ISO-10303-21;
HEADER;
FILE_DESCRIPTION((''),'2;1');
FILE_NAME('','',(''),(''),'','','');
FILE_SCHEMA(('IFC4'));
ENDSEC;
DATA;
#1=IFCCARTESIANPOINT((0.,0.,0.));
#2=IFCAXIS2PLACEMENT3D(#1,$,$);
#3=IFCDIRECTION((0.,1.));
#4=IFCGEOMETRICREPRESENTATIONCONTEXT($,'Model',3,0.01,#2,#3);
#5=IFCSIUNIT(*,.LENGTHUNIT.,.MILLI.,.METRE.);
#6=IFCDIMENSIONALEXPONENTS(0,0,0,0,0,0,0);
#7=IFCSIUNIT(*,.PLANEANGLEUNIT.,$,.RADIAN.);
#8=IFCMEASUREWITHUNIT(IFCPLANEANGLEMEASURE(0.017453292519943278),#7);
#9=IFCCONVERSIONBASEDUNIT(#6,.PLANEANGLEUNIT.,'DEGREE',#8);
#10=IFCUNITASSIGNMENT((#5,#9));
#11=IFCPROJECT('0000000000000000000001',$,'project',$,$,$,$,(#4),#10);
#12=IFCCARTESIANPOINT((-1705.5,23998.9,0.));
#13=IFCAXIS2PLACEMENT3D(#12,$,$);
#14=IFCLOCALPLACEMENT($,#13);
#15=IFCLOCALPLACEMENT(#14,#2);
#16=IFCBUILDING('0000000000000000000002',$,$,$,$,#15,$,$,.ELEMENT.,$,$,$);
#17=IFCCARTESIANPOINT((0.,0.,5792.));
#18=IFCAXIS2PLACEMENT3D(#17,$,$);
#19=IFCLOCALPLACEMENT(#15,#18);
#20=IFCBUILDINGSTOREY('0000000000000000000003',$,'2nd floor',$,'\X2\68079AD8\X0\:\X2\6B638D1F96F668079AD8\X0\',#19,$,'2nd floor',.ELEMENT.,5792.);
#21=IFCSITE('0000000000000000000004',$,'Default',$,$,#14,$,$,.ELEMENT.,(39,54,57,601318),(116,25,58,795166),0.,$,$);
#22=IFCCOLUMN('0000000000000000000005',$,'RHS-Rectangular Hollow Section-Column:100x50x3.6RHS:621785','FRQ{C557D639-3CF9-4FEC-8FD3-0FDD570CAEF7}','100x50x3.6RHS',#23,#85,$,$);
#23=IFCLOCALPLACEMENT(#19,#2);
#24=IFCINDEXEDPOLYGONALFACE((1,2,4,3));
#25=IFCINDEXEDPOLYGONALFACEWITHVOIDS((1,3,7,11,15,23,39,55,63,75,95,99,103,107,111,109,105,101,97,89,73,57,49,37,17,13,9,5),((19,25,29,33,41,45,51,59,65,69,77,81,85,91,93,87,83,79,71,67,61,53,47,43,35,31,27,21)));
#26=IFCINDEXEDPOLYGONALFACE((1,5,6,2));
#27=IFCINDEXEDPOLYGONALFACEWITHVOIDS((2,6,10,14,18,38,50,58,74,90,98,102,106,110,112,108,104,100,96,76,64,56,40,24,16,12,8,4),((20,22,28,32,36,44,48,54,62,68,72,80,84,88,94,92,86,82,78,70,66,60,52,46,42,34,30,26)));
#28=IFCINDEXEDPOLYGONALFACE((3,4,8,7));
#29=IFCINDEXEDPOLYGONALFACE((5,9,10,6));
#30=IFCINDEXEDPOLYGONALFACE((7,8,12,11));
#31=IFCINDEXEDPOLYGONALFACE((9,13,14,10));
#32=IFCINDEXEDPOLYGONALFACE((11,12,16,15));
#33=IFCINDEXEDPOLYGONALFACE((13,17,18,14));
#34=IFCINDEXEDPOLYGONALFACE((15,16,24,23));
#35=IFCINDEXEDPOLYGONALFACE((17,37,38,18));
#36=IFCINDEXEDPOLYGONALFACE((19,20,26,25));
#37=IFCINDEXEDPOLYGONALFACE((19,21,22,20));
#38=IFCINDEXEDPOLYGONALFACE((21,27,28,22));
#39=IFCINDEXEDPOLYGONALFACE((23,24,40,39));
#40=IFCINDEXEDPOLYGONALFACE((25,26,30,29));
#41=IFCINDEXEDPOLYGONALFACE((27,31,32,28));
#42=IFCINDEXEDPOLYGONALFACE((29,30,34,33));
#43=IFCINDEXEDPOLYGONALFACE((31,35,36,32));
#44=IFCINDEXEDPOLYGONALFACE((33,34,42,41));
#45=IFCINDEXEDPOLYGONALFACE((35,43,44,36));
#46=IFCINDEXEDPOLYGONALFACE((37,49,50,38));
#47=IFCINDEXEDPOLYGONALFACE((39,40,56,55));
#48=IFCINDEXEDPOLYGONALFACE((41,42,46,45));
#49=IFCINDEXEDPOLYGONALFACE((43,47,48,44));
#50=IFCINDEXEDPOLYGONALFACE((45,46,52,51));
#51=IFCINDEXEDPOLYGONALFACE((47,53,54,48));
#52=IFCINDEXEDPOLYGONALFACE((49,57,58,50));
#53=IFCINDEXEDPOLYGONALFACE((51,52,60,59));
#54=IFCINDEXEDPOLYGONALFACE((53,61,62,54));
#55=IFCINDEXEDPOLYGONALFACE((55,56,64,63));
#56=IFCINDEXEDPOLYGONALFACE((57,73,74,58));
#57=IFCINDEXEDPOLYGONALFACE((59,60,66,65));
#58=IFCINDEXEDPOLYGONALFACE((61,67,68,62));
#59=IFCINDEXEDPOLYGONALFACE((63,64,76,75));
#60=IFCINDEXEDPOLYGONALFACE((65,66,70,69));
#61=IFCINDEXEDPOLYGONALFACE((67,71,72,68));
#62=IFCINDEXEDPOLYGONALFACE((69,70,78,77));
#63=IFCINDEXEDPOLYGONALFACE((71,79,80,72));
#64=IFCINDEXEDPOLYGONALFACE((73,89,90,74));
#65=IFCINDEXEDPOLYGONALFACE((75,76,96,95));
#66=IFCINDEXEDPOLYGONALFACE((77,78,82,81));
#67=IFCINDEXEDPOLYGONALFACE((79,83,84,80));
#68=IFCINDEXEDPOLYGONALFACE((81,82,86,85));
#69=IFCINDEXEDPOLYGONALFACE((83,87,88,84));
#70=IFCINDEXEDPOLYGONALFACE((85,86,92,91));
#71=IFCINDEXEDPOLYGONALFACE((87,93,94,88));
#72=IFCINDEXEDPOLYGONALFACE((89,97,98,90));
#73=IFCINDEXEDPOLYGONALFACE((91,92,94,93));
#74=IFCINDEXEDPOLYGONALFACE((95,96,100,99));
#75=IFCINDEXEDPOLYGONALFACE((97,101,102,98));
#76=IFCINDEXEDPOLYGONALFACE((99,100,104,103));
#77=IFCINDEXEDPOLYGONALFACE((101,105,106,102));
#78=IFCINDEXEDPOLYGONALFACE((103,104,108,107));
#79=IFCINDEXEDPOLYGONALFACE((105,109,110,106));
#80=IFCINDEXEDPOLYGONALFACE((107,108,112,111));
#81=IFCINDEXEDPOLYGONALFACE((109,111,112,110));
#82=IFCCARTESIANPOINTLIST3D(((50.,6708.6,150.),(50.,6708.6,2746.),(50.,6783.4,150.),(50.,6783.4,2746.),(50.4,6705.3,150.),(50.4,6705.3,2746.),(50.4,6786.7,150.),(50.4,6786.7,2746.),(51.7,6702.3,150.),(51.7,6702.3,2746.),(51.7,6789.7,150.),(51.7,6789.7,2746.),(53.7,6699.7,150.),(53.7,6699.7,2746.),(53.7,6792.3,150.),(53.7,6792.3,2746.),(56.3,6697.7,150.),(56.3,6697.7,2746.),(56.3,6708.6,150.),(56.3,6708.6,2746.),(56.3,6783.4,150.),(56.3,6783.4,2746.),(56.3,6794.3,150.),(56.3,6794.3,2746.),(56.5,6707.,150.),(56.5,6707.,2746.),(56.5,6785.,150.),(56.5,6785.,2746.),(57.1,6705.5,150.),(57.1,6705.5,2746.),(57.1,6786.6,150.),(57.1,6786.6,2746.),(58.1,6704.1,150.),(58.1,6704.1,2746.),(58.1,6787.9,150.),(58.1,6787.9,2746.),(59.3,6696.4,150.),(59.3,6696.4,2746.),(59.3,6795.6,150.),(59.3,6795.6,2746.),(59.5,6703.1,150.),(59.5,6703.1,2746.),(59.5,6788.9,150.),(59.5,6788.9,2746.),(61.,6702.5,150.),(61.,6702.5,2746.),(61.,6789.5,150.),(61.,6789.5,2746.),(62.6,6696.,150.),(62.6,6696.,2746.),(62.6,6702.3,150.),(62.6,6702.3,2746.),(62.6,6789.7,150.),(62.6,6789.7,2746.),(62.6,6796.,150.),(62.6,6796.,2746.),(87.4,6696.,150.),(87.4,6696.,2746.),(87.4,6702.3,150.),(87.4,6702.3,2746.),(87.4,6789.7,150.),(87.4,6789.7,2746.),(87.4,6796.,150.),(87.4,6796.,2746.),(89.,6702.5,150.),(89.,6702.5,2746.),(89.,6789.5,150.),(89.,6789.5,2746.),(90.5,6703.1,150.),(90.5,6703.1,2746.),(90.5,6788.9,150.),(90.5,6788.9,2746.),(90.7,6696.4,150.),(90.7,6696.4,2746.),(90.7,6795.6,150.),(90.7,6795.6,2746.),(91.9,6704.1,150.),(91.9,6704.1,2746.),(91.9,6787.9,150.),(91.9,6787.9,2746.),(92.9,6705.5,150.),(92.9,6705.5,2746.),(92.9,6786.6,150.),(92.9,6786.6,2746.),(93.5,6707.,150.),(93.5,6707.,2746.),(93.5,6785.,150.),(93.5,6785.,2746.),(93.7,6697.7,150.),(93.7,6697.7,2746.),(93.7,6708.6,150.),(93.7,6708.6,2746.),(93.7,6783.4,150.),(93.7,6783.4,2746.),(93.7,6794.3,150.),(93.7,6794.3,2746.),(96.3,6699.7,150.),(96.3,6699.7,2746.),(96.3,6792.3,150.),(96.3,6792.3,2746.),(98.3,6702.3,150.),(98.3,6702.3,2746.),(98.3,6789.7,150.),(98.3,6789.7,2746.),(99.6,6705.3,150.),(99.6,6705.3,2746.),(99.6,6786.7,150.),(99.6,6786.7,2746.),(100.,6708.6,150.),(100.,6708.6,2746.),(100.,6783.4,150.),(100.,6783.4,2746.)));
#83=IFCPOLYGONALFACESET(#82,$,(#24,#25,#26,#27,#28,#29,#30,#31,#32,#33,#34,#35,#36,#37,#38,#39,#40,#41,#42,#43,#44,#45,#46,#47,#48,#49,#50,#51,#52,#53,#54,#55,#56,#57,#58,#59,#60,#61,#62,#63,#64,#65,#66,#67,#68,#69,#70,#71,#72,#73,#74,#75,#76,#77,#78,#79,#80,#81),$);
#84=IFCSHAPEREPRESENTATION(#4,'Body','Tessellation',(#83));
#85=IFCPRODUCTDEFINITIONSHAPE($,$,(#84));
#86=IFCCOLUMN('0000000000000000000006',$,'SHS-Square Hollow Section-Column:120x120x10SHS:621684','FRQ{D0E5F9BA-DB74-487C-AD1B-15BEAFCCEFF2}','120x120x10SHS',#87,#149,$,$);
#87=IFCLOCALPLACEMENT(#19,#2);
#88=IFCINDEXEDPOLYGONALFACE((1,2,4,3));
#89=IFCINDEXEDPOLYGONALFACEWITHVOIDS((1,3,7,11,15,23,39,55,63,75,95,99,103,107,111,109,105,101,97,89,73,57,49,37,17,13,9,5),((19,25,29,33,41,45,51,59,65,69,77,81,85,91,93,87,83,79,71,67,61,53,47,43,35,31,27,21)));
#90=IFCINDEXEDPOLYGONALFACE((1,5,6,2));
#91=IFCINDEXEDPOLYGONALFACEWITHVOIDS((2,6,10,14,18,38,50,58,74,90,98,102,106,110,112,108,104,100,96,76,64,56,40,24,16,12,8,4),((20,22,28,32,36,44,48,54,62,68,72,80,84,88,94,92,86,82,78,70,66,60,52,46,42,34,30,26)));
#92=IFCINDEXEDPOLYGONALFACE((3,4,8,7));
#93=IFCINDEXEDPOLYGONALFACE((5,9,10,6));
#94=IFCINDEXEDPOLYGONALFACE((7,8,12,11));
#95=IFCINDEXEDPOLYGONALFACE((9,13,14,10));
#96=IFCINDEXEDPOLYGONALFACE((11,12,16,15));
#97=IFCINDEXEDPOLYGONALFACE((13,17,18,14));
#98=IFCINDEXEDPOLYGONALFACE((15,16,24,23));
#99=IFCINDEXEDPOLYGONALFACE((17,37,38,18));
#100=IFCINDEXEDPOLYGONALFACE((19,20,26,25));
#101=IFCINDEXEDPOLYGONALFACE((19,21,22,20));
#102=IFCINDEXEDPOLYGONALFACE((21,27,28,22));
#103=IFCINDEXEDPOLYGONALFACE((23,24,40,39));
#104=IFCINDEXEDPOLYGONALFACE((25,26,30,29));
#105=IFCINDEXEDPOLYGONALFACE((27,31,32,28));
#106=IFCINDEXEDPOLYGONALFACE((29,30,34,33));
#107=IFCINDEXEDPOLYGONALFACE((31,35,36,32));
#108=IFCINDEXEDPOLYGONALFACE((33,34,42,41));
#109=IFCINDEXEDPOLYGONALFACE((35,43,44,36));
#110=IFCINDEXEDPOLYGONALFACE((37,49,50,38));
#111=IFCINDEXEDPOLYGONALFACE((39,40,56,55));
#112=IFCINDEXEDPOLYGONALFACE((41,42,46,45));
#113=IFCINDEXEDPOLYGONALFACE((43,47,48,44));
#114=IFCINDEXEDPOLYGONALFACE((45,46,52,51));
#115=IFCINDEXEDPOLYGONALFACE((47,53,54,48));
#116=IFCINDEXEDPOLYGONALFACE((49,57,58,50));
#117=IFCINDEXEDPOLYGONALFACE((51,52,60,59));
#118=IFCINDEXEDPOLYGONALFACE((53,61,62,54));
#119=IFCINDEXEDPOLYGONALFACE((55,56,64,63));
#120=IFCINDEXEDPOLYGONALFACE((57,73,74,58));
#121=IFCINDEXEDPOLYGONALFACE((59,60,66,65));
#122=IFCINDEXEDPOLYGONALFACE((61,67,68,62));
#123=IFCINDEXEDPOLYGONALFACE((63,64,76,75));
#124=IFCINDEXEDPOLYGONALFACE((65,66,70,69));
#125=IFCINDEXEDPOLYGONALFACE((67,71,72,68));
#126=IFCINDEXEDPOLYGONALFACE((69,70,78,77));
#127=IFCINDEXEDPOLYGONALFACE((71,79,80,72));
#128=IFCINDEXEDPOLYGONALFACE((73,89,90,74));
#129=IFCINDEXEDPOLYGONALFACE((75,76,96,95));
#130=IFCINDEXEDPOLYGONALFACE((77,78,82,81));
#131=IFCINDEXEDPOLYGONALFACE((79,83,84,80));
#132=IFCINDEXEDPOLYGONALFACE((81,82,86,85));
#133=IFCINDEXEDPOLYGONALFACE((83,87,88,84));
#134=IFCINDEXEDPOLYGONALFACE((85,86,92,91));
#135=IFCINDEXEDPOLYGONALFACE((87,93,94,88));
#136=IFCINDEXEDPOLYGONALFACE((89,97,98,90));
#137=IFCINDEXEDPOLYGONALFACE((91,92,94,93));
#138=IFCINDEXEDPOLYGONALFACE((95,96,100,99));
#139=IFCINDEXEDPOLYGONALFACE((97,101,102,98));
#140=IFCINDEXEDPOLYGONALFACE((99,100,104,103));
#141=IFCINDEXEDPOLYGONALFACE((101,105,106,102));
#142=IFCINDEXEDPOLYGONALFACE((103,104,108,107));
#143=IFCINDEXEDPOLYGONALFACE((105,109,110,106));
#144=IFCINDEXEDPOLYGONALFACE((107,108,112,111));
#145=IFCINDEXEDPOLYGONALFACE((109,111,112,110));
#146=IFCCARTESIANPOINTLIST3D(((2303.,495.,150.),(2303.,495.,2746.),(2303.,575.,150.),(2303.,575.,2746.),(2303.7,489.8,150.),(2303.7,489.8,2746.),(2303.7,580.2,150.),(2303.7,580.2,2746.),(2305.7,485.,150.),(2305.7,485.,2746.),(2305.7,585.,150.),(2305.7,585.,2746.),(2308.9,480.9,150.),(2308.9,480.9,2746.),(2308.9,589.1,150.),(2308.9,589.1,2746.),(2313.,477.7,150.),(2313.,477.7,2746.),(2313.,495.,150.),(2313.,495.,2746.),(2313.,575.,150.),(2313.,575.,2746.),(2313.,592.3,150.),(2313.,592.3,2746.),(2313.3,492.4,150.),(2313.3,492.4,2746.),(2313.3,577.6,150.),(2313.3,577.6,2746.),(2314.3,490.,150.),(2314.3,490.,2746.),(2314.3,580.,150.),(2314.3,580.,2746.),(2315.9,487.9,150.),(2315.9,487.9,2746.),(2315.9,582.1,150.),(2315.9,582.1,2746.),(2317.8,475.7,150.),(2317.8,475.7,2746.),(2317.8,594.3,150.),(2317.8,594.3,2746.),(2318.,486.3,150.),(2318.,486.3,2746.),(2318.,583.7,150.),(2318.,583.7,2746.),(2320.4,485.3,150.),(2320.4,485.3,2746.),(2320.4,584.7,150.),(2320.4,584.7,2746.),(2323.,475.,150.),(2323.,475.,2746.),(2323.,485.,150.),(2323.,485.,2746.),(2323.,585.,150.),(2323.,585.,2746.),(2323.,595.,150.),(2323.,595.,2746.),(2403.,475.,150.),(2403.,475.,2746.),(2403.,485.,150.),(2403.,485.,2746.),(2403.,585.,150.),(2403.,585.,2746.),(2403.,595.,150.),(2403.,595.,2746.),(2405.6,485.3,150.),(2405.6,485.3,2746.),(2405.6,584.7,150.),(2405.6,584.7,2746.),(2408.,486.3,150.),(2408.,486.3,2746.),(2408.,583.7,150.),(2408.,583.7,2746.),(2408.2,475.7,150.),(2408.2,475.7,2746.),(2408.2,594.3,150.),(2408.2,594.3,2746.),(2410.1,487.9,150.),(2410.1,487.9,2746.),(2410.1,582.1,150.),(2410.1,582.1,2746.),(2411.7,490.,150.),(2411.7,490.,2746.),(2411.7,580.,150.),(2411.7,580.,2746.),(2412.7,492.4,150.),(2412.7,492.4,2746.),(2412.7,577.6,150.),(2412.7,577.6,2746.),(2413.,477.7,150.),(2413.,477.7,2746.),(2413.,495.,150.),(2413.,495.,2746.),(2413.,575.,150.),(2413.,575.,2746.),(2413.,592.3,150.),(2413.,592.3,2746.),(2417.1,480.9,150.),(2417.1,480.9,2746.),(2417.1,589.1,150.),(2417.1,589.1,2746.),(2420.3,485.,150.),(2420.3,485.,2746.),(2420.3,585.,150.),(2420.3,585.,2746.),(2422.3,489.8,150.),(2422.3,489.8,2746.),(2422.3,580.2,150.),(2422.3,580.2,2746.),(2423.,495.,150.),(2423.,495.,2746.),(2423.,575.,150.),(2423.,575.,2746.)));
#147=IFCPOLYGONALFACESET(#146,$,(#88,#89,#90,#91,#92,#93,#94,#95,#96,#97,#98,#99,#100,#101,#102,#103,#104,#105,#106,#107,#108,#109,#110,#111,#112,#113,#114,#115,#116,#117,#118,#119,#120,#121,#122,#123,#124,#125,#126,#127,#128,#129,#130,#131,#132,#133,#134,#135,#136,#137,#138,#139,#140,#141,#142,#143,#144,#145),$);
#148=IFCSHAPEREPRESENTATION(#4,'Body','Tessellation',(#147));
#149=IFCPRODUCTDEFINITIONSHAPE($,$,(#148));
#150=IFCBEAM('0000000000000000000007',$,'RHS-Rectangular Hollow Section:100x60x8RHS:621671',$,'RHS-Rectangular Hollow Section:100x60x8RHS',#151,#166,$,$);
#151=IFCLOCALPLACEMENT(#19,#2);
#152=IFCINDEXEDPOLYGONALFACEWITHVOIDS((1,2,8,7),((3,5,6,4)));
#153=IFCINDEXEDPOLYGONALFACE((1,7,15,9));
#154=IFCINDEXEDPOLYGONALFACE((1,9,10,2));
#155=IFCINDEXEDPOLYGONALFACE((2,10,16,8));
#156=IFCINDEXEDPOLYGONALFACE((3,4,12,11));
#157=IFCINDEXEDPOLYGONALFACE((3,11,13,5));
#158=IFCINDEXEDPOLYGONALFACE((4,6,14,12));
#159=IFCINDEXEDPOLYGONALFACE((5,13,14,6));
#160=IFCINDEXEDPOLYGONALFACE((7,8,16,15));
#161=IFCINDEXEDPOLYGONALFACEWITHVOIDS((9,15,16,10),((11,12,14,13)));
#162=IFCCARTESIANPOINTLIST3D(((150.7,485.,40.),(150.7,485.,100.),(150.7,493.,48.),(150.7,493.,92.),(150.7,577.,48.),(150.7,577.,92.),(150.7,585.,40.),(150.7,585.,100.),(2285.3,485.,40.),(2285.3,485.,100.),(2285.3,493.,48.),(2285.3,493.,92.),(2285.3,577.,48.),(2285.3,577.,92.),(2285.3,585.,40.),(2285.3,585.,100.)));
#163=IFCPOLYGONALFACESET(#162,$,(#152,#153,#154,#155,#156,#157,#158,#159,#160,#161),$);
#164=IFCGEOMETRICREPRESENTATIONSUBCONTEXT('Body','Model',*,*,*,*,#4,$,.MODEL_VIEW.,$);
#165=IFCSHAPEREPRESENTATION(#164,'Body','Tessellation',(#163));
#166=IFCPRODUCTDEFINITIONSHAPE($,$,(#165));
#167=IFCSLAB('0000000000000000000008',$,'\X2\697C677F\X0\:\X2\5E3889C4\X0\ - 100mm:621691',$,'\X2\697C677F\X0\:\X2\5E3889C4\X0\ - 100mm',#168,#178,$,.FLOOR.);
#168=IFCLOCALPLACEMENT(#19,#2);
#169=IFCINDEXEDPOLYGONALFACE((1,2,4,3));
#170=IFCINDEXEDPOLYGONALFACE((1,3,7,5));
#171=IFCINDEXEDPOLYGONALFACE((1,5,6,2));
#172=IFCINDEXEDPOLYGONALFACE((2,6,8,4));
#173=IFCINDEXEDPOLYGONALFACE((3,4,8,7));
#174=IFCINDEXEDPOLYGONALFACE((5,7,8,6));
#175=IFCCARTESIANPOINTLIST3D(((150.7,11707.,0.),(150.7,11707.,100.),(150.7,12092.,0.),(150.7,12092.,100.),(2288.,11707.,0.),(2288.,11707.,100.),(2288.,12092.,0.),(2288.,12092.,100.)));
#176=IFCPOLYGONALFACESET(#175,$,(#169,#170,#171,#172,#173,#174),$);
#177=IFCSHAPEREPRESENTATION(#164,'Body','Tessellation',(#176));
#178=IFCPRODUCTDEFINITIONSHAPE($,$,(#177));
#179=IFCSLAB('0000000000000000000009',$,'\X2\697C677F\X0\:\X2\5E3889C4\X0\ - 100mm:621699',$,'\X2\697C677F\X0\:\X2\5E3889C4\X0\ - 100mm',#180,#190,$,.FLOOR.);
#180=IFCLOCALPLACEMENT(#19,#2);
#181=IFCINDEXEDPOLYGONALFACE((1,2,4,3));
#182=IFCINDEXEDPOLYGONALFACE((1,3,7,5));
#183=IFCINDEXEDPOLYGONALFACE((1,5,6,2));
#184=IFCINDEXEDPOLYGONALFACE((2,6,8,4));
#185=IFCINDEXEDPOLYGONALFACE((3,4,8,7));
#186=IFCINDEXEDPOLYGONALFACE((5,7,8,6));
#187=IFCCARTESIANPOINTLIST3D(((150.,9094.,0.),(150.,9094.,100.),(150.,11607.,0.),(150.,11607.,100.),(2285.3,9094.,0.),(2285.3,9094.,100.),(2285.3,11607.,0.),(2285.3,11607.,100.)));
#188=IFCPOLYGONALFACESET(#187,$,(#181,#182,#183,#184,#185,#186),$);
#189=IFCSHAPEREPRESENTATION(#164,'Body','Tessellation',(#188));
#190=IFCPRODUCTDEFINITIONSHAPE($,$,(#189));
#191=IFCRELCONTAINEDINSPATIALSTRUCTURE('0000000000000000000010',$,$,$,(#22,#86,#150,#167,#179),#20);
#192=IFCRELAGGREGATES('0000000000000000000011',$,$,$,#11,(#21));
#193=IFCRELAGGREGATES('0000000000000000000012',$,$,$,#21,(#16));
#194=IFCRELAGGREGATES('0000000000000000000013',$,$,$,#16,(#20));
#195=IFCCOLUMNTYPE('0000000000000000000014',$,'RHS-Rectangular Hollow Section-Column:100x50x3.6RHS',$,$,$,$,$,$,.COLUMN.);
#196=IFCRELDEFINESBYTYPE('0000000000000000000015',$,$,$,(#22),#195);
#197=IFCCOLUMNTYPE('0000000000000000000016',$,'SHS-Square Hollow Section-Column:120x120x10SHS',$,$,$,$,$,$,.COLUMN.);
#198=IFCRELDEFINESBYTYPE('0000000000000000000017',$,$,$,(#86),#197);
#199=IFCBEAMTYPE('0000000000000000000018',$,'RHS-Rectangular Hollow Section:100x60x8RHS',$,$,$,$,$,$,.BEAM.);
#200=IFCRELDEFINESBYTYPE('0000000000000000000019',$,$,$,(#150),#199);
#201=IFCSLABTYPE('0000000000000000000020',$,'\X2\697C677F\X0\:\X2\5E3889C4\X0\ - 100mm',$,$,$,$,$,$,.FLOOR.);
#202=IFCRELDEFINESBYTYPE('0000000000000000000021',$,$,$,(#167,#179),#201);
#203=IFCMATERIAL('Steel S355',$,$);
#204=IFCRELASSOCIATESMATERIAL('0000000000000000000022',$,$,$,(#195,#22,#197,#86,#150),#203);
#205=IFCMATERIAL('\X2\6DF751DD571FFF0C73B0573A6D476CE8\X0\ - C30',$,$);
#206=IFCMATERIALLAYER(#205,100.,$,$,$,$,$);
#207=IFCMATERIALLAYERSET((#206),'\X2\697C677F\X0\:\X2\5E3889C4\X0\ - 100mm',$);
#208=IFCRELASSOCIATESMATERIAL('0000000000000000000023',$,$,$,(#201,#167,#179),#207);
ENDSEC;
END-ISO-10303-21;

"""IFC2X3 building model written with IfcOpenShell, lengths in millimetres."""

from ifc_helpers import new_model, entity, si_unit, converted_unit, direction, frame, frame_2d, origin, origin_2d, origin_2d_with_axis, place, context, subcontext, project, spatial, rectangle, hollow_rectangle, extrude, boolean, clip, halfspace, material, layer, layer_set, layer_usage, type_object, element, save


model = new_model("IFC2X3")

# Units and contexts
model_context = context("Model", 3, precision=0.01, world=origin(), true_north=direction((0.0, 1.0)))
body_context = subcontext(model_context, "Body", "Model", "MODEL_VIEW")
ifc_project = project(units=[si_unit("LENGTHUNIT", "METRE", prefix="MILLI"), converted_unit("PLANEANGLEUNIT", "DEGREE", entity("IfcPlaneAngleMeasure", 0.017453292519943278), si_unit("PLANEANGLEUNIT", "RADIAN"), dimensions=[0, 0, 0, 0, 0, 0, 0])], contexts=[model_context])

# Site, building, storey
site_placement = place(None, frame((-1705.5, 23998.9, 0.0)))
site = spatial("IfcSite", under=ifc_project, at=site_placement, Name="Default", CompositionType="ELEMENT", RefLatitude=(39, 54, 57, 601318), RefLongitude=(116, 25, 58, 795166), RefElevation=0.0)
building_placement = place(site_placement, origin())
building = spatial("IfcBuilding", under=site, at=building_placement, CompositionType="ELEMENT")
storey_placement = place(building_placement, frame((0.0, 0.0, 5792.0)))
storey = spatial("IfcBuildingStorey", under=building, at=storey_placement, Name="2nd floor", ObjectType="标高:正负零标高", LongName="2nd floor", CompositionType="ELEMENT", Elevation=5792.0)

# Shared definitions
ifc_material_1 = material(Name="Steel S355")

# Columns
column_type_1 = type_object("IfcColumnType", Name="RHS-Rectangular Hollow Section-Column:100x50x3.6RHS", PredefinedType="COLUMN", material=ifc_material_1)
column_1_placement = place(storey_placement, frame((75.0, 6746.0, 2746.0), z_axis=(0.0, 0.0, 1.0), x_axis=(-1.0, 0.0, 0.0)))
element("IfcColumn", 1, at=column_1_placement, inside=storey, type_object=column_type_1, material=ifc_material_1, Name="RHS-Rectangular Hollow Section-Column:100x50x3.6RHS:621785", Description="FRQ{C557D639-3CF9-4FEC-8FD3-0FDD570CAEF7}", ObjectType="100x50x3.6RHS", context=model_context, shape_type="Clipping", body=[
    clip(extrude(hollow_rectangle(XDim=50.0, YDim=100.0, WallThickness=6.3, InnerFilletRadius=6.3, OuterFilletRadius=12.6, at=origin_2d()), origin(), (0.0, 0.0, -1.0), 2651.9), halfspace(frame((75.0, 6746.0, -2596.0), z_axis=(0.0, 0.0, 1.0), x_axis=(-1.0, 0.0, 0.0)), True)),
])
column_type_2 = type_object("IfcColumnType", Name="SHS-Square Hollow Section-Column:120x120x10SHS", PredefinedType="COLUMN", material=ifc_material_1)
column_2_placement = place(storey_placement, frame((2363.0, 535.0, 2746.0), z_axis=(0.0, 0.0, 1.0), x_axis=(0.0, -1.0, 0.0)))
element("IfcColumn", 2, at=column_2_placement, inside=storey, type_object=column_type_2, material=ifc_material_1, Name="SHS-Square Hollow Section-Column:120x120x10SHS:621684", Description="FRQ{D0E5F9BA-DB74-487C-AD1B-15BEAFCCEFF2}", ObjectType="120x120x10SHS", context=model_context, shape_type="Clipping", body=[
    clip(extrude(hollow_rectangle(XDim=120.0, YDim=120.0, WallThickness=10.0, InnerFilletRadius=10.0, OuterFilletRadius=20.0, at=origin_2d()), origin(), (0.0, 0.0, -1.0), 2680.9), halfspace(frame((535.0, -2363.0, -2596.0), z_axis=(0.0, 0.0, 1.0), x_axis=(0.0, 1.0, 0.0)), True)),
])

# Beam
beam_type_1 = type_object("IfcBeamType", Name="RHS-Rectangular Hollow Section:100x60x8RHS", PredefinedType="BEAM")
beam_1_placement = place(storey_placement, frame((150.7, 585.0, 70.0)))
element("IfcBeam", 3, at=beam_1_placement, inside=storey, type_object=beam_type_1, material=ifc_material_1, Name="RHS-Rectangular Hollow Section:100x60x8RHS:621671", ObjectType="RHS-Rectangular Hollow Section:100x60x8RHS", context=body_context, shape_type="SweptSolid", body=[
    boolean("DIFFERENCE", extrude(rectangle(XDim=60.0, YDim=100.0, at=frame_2d((0.0, 0.0), x_axis=(1.0, 0.0))), frame((0.0, -50.0, 0.0), z_axis=(1.0, 0.0, 0.0), x_axis=(0.0, 0.0, -1.0)), (0.0, 0.0, 1.0), 2134.6), extrude(rectangle(XDim=44.0, YDim=84.0, at=frame_2d((0.0, 0.0), x_axis=(0.0, 1.0))), frame((2134.6, -50.0, 0.0), z_axis=(-1.0, 0.0, 0.0), x_axis=(0.0, 1.0, 0.0)), (0.0, 0.0, 1.0), 2134.6)),
])

# Slabs
ifc_material_2 = material(Name="混凝土，现场浇注 - C30")
ifc_layer_1 = layer(ifc_material_2, 100.0)
ifc_layer_set_1 = layer_set([ifc_layer_1], Name="楼板:常规 - 100mm")
ifc_layer_usage_1 = layer_usage(ifc_layer_set_1, "AXIS3", "POSITIVE", 0.0)
slab_type = type_object("IfcSlabType", Name="楼板:常规 - 100mm", PredefinedType="FLOOR", material=ifc_layer_set_1)
slab_1_placement = place(storey_placement, origin())
element("IfcSlab", 4, at=slab_1_placement, inside=storey, type_object=slab_type, material=ifc_layer_usage_1, Name="楼板:常规 - 100mm:621691", ObjectType="楼板:常规 - 100mm", PredefinedType="FLOOR", context=body_context, shape_type="SweptSolid", body=[
    extrude(rectangle(XDim=385.0, YDim=2137.3, at=origin_2d_with_axis()), frame((1219.3, 11899.5, 100.0), z_axis=(0.0, 0.0, -1.0), x_axis=(0.0, 1.0, 0.0)), (0.0, 0.0, 1.0), 100.0),
])
ifc_layer_usage_2 = layer_usage(ifc_layer_set_1, "AXIS3", "POSITIVE", 0.0)
slab_2_placement = place(storey_placement, origin())
element("IfcSlab", 5, at=slab_2_placement, inside=storey, type_object=slab_type, material=ifc_layer_usage_2, Name="楼板:常规 - 100mm:621699", ObjectType="楼板:常规 - 100mm", PredefinedType="FLOOR", context=body_context, shape_type="SweptSolid", body=[
    extrude(rectangle(XDim=2513.0, YDim=2135.3, at=frame_2d((0.0, 0.0), x_axis=(1.0, 0.0))), frame((1217.6, 10350.5, 100.0), z_axis=(0.0, 0.0, -1.0), x_axis=(0.0, 1.0, 0.0)), (0.0, 0.0, 1.0), 100.0),
])

save(model, "model.ifc")
